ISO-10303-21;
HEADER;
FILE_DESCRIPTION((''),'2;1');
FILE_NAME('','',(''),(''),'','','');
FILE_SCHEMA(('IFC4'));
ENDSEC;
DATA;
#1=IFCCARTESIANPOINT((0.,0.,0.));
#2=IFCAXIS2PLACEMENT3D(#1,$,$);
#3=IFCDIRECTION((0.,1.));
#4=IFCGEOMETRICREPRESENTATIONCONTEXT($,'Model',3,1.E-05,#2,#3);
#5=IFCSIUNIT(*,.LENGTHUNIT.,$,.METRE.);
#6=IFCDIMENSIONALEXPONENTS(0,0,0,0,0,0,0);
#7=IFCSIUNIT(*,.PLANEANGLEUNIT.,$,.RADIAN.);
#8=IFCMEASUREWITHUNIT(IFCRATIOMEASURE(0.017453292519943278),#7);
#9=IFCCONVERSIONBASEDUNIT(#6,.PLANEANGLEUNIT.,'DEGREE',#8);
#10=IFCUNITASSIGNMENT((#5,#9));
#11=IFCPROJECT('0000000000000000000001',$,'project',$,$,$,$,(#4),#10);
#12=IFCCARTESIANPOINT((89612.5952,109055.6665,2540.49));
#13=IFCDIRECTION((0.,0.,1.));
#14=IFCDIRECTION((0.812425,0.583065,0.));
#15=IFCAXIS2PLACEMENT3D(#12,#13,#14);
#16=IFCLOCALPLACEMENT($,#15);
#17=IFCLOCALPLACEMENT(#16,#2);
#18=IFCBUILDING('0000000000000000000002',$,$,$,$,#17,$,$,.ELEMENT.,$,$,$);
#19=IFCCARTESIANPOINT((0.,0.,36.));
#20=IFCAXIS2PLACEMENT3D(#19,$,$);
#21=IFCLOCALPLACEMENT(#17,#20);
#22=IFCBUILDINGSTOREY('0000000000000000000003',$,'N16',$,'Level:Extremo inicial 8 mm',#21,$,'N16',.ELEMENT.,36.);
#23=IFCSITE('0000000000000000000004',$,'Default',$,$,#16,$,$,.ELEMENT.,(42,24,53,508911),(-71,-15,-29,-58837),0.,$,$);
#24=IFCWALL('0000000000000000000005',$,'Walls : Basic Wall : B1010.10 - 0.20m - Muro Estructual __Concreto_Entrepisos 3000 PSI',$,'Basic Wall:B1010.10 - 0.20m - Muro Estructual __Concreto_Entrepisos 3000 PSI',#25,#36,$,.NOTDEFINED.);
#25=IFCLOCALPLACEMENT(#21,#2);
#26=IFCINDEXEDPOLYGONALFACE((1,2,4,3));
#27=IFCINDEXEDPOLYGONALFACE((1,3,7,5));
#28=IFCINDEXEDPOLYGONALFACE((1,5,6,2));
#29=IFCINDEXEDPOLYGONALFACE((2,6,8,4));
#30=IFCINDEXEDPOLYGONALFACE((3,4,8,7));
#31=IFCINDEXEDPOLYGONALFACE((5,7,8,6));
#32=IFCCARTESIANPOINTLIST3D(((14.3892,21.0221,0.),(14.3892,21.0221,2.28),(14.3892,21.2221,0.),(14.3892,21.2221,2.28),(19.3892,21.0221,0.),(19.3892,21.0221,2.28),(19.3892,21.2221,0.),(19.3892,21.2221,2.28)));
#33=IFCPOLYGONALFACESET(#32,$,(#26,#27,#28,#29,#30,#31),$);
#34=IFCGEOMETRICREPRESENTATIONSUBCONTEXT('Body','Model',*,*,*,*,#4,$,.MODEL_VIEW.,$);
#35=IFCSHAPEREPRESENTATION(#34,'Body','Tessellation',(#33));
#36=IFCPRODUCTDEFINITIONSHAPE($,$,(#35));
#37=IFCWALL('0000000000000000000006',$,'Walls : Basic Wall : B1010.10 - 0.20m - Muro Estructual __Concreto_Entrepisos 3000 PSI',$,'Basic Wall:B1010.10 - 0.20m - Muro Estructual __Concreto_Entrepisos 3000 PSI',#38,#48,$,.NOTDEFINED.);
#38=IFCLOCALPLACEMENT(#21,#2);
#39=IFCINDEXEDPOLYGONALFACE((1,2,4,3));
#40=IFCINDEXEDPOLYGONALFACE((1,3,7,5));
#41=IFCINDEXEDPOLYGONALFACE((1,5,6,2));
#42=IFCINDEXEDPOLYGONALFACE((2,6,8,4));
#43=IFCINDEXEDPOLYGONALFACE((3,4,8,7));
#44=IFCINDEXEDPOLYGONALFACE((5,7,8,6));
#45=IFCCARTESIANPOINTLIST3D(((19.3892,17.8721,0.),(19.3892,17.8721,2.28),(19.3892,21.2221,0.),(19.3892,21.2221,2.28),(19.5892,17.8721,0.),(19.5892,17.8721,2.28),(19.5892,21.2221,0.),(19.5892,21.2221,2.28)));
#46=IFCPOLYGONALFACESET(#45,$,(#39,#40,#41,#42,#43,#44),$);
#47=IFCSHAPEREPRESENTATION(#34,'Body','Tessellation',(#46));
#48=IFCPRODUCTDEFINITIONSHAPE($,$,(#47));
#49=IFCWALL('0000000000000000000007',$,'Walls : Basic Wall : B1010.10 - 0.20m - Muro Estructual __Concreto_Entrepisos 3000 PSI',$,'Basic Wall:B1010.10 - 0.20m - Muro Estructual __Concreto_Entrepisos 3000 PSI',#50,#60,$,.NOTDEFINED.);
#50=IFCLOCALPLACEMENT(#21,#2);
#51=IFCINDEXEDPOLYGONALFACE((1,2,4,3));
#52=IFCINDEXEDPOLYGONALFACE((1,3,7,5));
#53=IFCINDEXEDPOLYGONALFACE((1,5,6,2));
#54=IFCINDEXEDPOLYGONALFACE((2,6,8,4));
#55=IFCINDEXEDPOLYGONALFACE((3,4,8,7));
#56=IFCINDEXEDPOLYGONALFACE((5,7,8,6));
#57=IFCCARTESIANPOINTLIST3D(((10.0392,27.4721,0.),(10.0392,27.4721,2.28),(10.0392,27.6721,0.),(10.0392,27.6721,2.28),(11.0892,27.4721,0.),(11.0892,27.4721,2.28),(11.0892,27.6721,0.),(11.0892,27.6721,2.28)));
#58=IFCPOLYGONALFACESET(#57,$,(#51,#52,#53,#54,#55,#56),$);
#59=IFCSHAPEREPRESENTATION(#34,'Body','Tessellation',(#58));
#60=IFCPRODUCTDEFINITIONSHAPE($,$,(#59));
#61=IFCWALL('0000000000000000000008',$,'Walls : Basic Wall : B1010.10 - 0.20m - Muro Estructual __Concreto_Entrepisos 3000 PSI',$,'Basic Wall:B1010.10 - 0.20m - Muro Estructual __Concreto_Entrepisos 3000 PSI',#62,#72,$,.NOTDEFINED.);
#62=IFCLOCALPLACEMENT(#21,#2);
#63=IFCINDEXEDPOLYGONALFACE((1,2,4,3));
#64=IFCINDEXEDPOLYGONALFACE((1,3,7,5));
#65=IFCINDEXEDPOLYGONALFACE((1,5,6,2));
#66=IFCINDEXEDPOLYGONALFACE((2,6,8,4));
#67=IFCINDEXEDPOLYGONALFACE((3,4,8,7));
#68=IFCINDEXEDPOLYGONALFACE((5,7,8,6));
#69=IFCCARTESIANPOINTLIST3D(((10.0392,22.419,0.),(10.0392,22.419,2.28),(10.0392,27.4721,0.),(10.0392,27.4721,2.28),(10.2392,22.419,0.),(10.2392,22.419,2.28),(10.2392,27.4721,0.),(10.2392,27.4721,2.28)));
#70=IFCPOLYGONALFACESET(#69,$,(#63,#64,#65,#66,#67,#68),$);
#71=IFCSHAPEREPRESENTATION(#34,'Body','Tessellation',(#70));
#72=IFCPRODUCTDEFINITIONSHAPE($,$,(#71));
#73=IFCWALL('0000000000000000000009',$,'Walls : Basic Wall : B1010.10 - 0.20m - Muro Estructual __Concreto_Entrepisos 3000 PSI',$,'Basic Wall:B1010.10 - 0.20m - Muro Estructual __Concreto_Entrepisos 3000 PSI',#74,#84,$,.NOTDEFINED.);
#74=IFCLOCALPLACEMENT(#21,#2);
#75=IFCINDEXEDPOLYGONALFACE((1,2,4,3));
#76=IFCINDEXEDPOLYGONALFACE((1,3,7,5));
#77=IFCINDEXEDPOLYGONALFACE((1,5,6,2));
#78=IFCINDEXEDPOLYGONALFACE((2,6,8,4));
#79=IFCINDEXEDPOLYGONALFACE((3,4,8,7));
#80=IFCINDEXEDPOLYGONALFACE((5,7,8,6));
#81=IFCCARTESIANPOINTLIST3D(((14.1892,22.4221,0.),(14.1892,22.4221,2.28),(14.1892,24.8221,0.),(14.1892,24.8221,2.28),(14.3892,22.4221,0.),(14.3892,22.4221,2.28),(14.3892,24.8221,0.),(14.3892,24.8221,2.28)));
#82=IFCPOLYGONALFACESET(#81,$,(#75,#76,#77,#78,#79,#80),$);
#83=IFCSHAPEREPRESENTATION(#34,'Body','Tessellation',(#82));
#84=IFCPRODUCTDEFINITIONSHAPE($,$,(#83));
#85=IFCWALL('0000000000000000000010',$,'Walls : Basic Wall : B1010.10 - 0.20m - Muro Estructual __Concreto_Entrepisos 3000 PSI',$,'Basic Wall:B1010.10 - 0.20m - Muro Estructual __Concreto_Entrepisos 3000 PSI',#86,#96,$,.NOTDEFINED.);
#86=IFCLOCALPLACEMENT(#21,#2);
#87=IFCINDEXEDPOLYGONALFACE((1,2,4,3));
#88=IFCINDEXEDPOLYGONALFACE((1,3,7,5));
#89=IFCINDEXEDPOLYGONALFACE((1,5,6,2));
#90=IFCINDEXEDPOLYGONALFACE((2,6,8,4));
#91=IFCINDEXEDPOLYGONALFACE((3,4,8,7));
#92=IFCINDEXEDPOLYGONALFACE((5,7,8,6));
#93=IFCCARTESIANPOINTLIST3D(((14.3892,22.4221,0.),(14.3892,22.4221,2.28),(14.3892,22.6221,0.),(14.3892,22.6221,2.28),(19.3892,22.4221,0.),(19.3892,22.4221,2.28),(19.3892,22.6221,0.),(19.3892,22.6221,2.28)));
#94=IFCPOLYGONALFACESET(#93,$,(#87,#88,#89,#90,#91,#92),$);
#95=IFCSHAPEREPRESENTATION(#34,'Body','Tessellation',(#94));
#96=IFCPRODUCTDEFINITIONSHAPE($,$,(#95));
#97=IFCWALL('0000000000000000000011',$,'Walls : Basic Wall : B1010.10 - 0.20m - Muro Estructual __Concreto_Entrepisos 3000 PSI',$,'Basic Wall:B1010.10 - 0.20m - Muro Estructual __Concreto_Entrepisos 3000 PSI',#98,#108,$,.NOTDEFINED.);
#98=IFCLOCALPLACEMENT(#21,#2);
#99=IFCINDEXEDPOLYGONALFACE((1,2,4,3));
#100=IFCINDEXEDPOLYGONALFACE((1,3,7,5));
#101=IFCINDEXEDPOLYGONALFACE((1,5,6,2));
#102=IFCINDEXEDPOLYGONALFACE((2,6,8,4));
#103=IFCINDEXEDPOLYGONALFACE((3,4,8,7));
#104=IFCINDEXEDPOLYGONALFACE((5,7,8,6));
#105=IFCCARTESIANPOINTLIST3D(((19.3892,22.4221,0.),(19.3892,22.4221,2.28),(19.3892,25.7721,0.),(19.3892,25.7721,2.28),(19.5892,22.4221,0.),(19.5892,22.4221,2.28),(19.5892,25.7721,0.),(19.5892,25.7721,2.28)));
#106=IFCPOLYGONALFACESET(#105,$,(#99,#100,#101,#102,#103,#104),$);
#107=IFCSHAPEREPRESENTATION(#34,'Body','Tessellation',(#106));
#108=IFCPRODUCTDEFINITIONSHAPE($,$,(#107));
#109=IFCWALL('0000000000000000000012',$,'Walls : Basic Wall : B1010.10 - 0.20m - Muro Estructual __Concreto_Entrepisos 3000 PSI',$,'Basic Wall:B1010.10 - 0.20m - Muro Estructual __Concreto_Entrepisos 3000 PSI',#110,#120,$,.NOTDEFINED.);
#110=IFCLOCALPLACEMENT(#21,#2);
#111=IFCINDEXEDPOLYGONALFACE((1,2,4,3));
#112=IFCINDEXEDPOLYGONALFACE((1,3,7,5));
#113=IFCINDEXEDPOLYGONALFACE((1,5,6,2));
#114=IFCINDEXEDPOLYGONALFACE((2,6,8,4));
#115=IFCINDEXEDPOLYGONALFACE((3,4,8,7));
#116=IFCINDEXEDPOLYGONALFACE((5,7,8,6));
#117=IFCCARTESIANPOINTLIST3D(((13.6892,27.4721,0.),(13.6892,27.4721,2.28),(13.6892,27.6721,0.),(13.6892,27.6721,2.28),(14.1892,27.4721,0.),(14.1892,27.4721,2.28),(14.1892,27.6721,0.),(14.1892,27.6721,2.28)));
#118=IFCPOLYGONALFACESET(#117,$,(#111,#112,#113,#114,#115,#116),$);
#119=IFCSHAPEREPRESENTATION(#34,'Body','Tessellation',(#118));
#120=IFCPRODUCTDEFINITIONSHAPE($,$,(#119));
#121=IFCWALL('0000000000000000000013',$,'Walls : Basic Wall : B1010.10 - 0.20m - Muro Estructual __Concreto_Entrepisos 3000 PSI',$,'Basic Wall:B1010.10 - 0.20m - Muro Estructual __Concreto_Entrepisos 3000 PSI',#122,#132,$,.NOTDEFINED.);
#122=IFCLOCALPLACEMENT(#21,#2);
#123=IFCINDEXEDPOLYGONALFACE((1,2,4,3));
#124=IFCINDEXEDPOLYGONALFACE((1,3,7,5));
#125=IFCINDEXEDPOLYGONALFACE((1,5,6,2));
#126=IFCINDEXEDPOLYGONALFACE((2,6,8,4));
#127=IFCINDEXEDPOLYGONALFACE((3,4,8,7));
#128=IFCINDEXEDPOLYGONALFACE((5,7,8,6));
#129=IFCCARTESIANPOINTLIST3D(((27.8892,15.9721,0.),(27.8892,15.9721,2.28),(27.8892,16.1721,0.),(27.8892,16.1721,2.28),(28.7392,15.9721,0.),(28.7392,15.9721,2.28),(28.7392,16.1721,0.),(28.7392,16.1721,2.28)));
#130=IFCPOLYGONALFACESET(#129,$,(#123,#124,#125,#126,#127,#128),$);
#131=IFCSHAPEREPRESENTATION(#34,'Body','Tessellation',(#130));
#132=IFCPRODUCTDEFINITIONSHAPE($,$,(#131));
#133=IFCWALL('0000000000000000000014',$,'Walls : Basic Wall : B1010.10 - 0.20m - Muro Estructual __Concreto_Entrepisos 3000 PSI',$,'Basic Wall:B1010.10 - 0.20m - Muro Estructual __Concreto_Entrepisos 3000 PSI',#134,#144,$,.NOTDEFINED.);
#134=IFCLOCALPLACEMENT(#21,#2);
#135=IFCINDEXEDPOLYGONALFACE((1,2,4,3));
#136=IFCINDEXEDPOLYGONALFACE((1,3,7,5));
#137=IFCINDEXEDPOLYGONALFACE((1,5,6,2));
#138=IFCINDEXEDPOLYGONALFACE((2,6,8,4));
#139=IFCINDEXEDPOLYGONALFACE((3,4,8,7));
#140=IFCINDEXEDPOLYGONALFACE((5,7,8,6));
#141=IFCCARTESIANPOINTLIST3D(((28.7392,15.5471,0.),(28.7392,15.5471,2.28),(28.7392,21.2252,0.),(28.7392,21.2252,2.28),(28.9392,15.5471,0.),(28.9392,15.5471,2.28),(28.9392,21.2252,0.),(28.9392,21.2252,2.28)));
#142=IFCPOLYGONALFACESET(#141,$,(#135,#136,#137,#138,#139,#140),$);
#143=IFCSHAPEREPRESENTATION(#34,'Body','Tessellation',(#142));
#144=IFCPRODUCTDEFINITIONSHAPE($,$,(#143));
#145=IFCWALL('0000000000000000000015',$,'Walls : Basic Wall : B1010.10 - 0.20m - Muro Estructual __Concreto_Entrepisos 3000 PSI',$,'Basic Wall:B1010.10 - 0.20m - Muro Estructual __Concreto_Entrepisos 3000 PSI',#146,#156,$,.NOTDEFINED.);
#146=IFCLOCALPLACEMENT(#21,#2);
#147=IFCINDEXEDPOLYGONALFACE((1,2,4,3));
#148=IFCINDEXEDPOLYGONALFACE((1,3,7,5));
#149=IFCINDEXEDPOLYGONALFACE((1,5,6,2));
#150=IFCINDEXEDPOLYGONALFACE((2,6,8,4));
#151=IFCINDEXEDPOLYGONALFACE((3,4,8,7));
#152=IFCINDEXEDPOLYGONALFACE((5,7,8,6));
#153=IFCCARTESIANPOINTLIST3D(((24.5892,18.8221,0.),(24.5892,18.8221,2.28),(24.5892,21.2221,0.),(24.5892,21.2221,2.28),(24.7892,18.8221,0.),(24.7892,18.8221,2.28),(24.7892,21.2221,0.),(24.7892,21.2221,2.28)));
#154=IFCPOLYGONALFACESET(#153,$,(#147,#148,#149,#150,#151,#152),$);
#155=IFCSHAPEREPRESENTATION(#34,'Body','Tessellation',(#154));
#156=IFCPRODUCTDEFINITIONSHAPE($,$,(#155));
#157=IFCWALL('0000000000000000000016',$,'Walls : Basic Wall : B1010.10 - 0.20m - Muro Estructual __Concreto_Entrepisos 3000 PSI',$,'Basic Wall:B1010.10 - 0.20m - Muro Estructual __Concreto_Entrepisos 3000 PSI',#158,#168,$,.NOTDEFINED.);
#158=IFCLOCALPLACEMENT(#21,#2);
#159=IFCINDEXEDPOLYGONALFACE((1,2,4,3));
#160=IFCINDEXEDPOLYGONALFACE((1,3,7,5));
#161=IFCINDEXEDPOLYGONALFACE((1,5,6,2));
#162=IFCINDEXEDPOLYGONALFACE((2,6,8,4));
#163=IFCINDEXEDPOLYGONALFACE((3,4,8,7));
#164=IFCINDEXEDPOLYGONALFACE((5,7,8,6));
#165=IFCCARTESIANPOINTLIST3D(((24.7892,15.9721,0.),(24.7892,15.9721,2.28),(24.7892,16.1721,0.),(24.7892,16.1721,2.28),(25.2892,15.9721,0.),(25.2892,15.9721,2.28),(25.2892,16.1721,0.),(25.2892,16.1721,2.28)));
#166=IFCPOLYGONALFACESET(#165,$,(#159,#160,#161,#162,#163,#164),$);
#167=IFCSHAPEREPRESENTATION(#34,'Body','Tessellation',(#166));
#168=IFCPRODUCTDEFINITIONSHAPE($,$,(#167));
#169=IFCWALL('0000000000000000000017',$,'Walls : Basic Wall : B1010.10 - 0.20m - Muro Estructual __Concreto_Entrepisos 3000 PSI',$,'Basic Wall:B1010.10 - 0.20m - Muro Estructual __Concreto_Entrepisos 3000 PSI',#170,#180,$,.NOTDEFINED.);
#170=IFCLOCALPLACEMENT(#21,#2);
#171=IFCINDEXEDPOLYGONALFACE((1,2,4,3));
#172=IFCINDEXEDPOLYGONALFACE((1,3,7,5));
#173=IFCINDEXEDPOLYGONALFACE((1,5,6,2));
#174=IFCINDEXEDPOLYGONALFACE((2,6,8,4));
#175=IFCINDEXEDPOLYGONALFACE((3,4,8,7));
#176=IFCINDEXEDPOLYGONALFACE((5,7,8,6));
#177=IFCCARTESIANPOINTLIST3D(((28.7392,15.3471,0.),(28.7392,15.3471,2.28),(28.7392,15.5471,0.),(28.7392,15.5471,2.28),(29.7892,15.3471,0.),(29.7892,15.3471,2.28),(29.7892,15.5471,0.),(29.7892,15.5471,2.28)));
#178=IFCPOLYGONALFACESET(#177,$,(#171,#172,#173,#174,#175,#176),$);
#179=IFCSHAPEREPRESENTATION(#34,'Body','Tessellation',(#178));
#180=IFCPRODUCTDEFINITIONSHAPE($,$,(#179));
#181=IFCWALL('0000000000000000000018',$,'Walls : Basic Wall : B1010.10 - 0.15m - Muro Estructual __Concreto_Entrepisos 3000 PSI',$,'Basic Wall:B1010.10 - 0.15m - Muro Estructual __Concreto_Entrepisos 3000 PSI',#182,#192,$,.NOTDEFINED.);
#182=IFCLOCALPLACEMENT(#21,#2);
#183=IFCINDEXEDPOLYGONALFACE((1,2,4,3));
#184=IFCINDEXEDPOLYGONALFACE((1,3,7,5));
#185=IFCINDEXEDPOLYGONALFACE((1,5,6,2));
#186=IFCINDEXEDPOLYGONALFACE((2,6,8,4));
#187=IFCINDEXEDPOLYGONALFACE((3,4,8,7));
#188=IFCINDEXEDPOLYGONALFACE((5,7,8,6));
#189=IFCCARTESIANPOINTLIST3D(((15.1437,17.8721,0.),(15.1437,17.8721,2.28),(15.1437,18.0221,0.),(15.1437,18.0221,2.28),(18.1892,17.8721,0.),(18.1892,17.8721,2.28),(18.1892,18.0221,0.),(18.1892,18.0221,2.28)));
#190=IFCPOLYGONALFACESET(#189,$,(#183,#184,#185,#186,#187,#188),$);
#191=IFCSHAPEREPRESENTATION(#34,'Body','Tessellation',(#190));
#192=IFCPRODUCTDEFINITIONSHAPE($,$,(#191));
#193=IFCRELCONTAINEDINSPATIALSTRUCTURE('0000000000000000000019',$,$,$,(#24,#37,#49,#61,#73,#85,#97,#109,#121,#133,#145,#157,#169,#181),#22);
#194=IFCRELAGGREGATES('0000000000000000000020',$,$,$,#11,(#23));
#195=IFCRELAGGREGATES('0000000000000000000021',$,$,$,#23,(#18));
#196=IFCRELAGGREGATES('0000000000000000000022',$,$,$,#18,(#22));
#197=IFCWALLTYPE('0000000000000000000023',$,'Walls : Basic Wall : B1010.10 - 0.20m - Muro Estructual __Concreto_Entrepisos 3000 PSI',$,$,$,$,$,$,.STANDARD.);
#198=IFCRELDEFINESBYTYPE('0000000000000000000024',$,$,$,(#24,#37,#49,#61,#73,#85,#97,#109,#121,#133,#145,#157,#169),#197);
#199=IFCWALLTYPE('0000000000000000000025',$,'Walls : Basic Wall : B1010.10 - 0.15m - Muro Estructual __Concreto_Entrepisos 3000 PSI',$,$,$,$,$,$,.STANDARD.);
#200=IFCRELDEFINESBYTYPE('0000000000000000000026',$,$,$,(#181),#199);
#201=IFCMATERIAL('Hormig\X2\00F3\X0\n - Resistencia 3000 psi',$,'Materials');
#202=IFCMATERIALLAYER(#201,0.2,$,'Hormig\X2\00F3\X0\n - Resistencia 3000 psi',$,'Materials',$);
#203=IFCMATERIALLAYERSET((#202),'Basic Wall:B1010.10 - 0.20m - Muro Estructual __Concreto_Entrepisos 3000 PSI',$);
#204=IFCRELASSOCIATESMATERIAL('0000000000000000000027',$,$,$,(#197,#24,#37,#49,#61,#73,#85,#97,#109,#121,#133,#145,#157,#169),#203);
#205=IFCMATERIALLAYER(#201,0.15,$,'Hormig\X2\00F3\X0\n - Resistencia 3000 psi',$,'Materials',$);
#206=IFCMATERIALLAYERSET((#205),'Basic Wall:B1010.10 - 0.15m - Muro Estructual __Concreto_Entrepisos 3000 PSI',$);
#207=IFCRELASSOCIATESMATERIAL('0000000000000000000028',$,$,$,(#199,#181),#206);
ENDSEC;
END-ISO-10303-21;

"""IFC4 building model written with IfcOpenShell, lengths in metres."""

from ifc_helpers import new_model, entity, si_unit, converted_unit, direction, frame, frame_2d, origin, place, context, subcontext, project, spatial, rectangle, extrude, material, layer, layer_set, layer_usage, type_object, element, save


model = new_model("IFC4")

# Units and contexts
model_context = context("Model", 3, precision=1e-05, world=origin(), true_north=direction((0.0, 1.0)))
body_context = subcontext(model_context, "Body", "Model", "MODEL_VIEW")
ifc_project = project(units=[si_unit("LENGTHUNIT", "METRE"), converted_unit("PLANEANGLEUNIT", "DEGREE", entity("IfcRatioMeasure", 0.017453292519943278), si_unit("PLANEANGLEUNIT", "RADIAN"), dimensions=[0, 0, 0, 0, 0, 0, 0])], contexts=[model_context])

# Site, building, storey
site_placement = place(None, frame((89612.5952, 109055.6665, 2540.49), z_axis=(0.0, 0.0, 1.0), x_axis=(0.812425, 0.583065, 0.0)))
site = spatial("IfcSite", under=ifc_project, at=site_placement, Name="Default", CompositionType="ELEMENT", RefLatitude=(42, 24, 53, 508911), RefLongitude=(-71, -15, -29, -58837), RefElevation=0.0)
building_placement = place(site_placement, origin())
building = spatial("IfcBuilding", under=site, at=building_placement, CompositionType="ELEMENT")
storey_placement = place(building_placement, frame((0.0, 0.0, 36.0)))
storey = spatial("IfcBuildingStorey", under=building, at=storey_placement, Name="N16", ObjectType="Level:Extremo inicial 8 mm", LongName="N16", CompositionType="ELEMENT", Elevation=36.0)

# Walls
ifc_material = material(Name="Hormigón - Resistencia 3000 psi", Category="Materials")
ifc_layer_1 = layer(ifc_material, 0.2, Name="Hormigón - Resistencia 3000 psi", Category="Materials")
ifc_layer_set_1 = layer_set([ifc_layer_1], Name="Basic Wall:B1010.10 - 0.20m - Muro Estructual __Concreto_Entrepisos 3000 PSI")
ifc_layer_usage_1 = layer_usage(ifc_layer_set_1, "AXIS2", "NEGATIVE", 0.1)
wall_type_1 = type_object("IfcWallType", Name="Walls : Basic Wall : B1010.10 - 0.20m - Muro Estructual __Concreto_Entrepisos 3000 PSI", PredefinedType="STANDARD", material=ifc_layer_set_1)
wall_1_placement = place(storey_placement, frame((14.3892, 21.1221, 0.0)))
element("IfcWall", 1, at=wall_1_placement, inside=storey, type_object=wall_type_1, material=ifc_layer_usage_1, Name="Walls : Basic Wall : B1010.10 - 0.20m - Muro Estructual __Concreto_Entrepisos 3000 PSI", ObjectType="Basic Wall:B1010.10 - 0.20m - Muro Estructual __Concreto_Entrepisos 3000 PSI", PredefinedType="NOTDEFINED", context=body_context, shape_type="SweptSolid", body=[
    extrude(rectangle(XDim=5.0, YDim=0.2, at=frame_2d((2.5, 0.0), x_axis=(-1.0, 0.0))), origin(), (0.0, 0.0, 1.0), 2.28),
])
ifc_layer_usage_2 = layer_usage(ifc_layer_set_1, "AXIS2", "NEGATIVE", 0.1)
wall_2_placement = place(storey_placement, frame((19.4892, 21.2221, 0.0), z_axis=(0.0, 0.0, 1.0), x_axis=(0.0, -1.0, 0.0)))
element("IfcWall", 2, at=wall_2_placement, inside=storey, type_object=wall_type_1, material=ifc_layer_usage_2, Name="Walls : Basic Wall : B1010.10 - 0.20m - Muro Estructual __Concreto_Entrepisos 3000 PSI", ObjectType="Basic Wall:B1010.10 - 0.20m - Muro Estructual __Concreto_Entrepisos 3000 PSI", PredefinedType="NOTDEFINED", context=body_context, shape_type="SweptSolid", body=[
    extrude(rectangle(XDim=3.35, YDim=0.2, at=frame_2d((1.675, 0.0), x_axis=(-1.0, 0.0))), origin(), (0.0, 0.0, 1.0), 2.28),
])
ifc_layer_usage_3 = layer_usage(ifc_layer_set_1, "AXIS2", "POSITIVE", -0.1)
wall_3_placement = place(storey_placement, frame((11.0892, 27.5721, 0.0), z_axis=(0.0, 0.0, 1.0), x_axis=(-1.0, 0.0, 0.0)))
element("IfcWall", 3, at=wall_3_placement, inside=storey, type_object=wall_type_1, material=ifc_layer_usage_3, Name="Walls : Basic Wall : B1010.10 - 0.20m - Muro Estructual __Concreto_Entrepisos 3000 PSI", ObjectType="Basic Wall:B1010.10 - 0.20m - Muro Estructual __Concreto_Entrepisos 3000 PSI", PredefinedType="NOTDEFINED", context=body_context, shape_type="SweptSolid", body=[
    extrude(rectangle(XDim=1.05, YDim=0.2, at=frame_2d((0.525, 0.0), x_axis=(-1.0, 0.0))), origin(), (0.0, 0.0, 1.0), 2.28),
])
ifc_layer_usage_4 = layer_usage(ifc_layer_set_1, "AXIS2", "POSITIVE", -0.1)
wall_4_placement = place(storey_placement, frame((10.1392, 27.4721, 0.0), z_axis=(0.0, 0.0, 1.0), x_axis=(0.0, -1.0, 0.0)))
element("IfcWall", 4, at=wall_4_placement, inside=storey, type_object=wall_type_1, material=ifc_layer_usage_4, Name="Walls : Basic Wall : B1010.10 - 0.20m - Muro Estructual __Concreto_Entrepisos 3000 PSI", ObjectType="Basic Wall:B1010.10 - 0.20m - Muro Estructual __Concreto_Entrepisos 3000 PSI", PredefinedType="NOTDEFINED", context=body_context, shape_type="SweptSolid", body=[
    extrude(rectangle(XDim=5.0531, YDim=0.2, at=frame_2d((2.5265, 0.0), x_axis=(-1.0, 0.0))), origin(), (0.0, 0.0, 1.0), 2.28),
])
ifc_layer_usage_5 = layer_usage(ifc_layer_set_1, "AXIS2", "POSITIVE", -0.1)
wall_5_placement = place(storey_placement, frame((14.2892, 24.8221, 0.0), z_axis=(0.0, 0.0, 1.0), x_axis=(0.0, -1.0, 0.0)))
element("IfcWall", 5, at=wall_5_placement, inside=storey, type_object=wall_type_1, material=ifc_layer_usage_5, Name="Walls : Basic Wall : B1010.10 - 0.20m - Muro Estructual __Concreto_Entrepisos 3000 PSI", ObjectType="Basic Wall:B1010.10 - 0.20m - Muro Estructual __Concreto_Entrepisos 3000 PSI", PredefinedType="NOTDEFINED", context=body_context, shape_type="SweptSolid", body=[
    extrude(rectangle(XDim=2.4, YDim=0.2, at=frame_2d((1.2, 0.0), x_axis=(-1.0, 0.0))), origin(), (0.0, 0.0, 1.0), 2.28),
])
ifc_layer_usage_6 = layer_usage(ifc_layer_set_1, "AXIS2", "POSITIVE", -0.1)
wall_6_placement = place(storey_placement, frame((14.3892, 22.5221, 0.0)))
element("IfcWall", 6, at=wall_6_placement, inside=storey, type_object=wall_type_1, material=ifc_layer_usage_6, Name="Walls : Basic Wall : B1010.10 - 0.20m - Muro Estructual __Concreto_Entrepisos 3000 PSI", ObjectType="Basic Wall:B1010.10 - 0.20m - Muro Estructual __Concreto_Entrepisos 3000 PSI", PredefinedType="NOTDEFINED", context=body_context, shape_type="SweptSolid", body=[
    extrude(rectangle(XDim=5.0, YDim=0.2, at=frame_2d((2.5, 0.0), x_axis=(-1.0, 0.0))), origin(), (0.0, 0.0, 1.0), 2.28),
])
ifc_layer_usage_7 = layer_usage(ifc_layer_set_1, "AXIS2", "POSITIVE", -0.1)
wall_7_placement = place(storey_placement, frame((19.4892, 22.4221, 0.0), z_axis=(0.0, 0.0, 1.0), x_axis=(0.0, 1.0, 0.0)))
element("IfcWall", 7, at=wall_7_placement, inside=storey, type_object=wall_type_1, material=ifc_layer_usage_7, Name="Walls : Basic Wall : B1010.10 - 0.20m - Muro Estructual __Concreto_Entrepisos 3000 PSI", ObjectType="Basic Wall:B1010.10 - 0.20m - Muro Estructual __Concreto_Entrepisos 3000 PSI", PredefinedType="NOTDEFINED", context=body_context, shape_type="SweptSolid", body=[
    extrude(rectangle(XDim=3.35, YDim=0.2, at=frame_2d((1.675, 0.0), x_axis=(-1.0, 0.0))), origin(), (0.0, 0.0, 1.0), 2.28),
])
ifc_layer_usage_8 = layer_usage(ifc_layer_set_1, "AXIS2", "POSITIVE", -0.1)
wall_8_placement = place(storey_placement, frame((13.6892, 27.5721, 0.0)))
element("IfcWall", 8, at=wall_8_placement, inside=storey, type_object=wall_type_1, material=ifc_layer_usage_8, Name="Walls : Basic Wall : B1010.10 - 0.20m - Muro Estructual __Concreto_Entrepisos 3000 PSI", ObjectType="Basic Wall:B1010.10 - 0.20m - Muro Estructual __Concreto_Entrepisos 3000 PSI", PredefinedType="NOTDEFINED", context=body_context, shape_type="SweptSolid", body=[
    extrude(rectangle(XDim=0.5, YDim=0.2, at=frame_2d((0.25, 0.0), x_axis=(-1.0, 0.0))), origin(), (0.0, 0.0, 1.0), 2.28),
])
ifc_layer_usage_9 = layer_usage(ifc_layer_set_1, "AXIS2", "POSITIVE", -0.1)
wall_9_placement = place(storey_placement, frame((27.8892, 16.0721, 0.0)))
element("IfcWall", 9, at=wall_9_placement, inside=storey, type_object=wall_type_1, material=ifc_layer_usage_9, Name="Walls : Basic Wall : B1010.10 - 0.20m - Muro Estructual __Concreto_Entrepisos 3000 PSI", ObjectType="Basic Wall:B1010.10 - 0.20m - Muro Estructual __Concreto_Entrepisos 3000 PSI", PredefinedType="NOTDEFINED", context=body_context, shape_type="SweptSolid", body=[
    extrude(rectangle(XDim=0.85, YDim=0.2, at=frame_2d((0.425, 0.0), x_axis=(-1.0, 0.0))), origin(), (0.0, 0.0, 1.0), 2.28),
])
ifc_layer_usage_10 = layer_usage(ifc_layer_set_1, "AXIS2", "POSITIVE", -0.1)
wall_10_placement = place(storey_placement, frame((28.8392, 15.5471, 0.0), z_axis=(0.0, 0.0, 1.0), x_axis=(0.0, 1.0, 0.0)))
element("IfcWall", 10, at=wall_10_placement, inside=storey, type_object=wall_type_1, material=ifc_layer_usage_10, Name="Walls : Basic Wall : B1010.10 - 0.20m - Muro Estructual __Concreto_Entrepisos 3000 PSI", ObjectType="Basic Wall:B1010.10 - 0.20m - Muro Estructual __Concreto_Entrepisos 3000 PSI", PredefinedType="NOTDEFINED", context=body_context, shape_type="SweptSolid", body=[
    extrude(rectangle(XDim=5.6781, YDim=0.2, at=frame_2d((2.839, 0.0), x_axis=(-1.0, 0.0))), origin(), (0.0, 0.0, 1.0), 2.28),
])
ifc_layer_usage_11 = layer_usage(ifc_layer_set_1, "AXIS2", "POSITIVE", -0.1)
wall_11_placement = place(storey_placement, frame((24.6892, 18.8221, 0.0), z_axis=(0.0, 0.0, 1.0), x_axis=(0.0, 1.0, 0.0)))
element("IfcWall", 11, at=wall_11_placement, inside=storey, type_object=wall_type_1, material=ifc_layer_usage_11, Name="Walls : Basic Wall : B1010.10 - 0.20m - Muro Estructual __Concreto_Entrepisos 3000 PSI", ObjectType="Basic Wall:B1010.10 - 0.20m - Muro Estructual __Concreto_Entrepisos 3000 PSI", PredefinedType="NOTDEFINED", context=body_context, shape_type="SweptSolid", body=[
    extrude(rectangle(XDim=2.4, YDim=0.2, at=frame_2d((1.2, 0.0), x_axis=(-1.0, 0.0))), origin(), (0.0, 0.0, 1.0), 2.28),
])
ifc_layer_usage_12 = layer_usage(ifc_layer_set_1, "AXIS2", "POSITIVE", -0.1)
wall_12_placement = place(storey_placement, frame((25.2892, 16.0721, 0.0), z_axis=(0.0, 0.0, 1.0), x_axis=(-1.0, 0.0, 0.0)))
element("IfcWall", 12, at=wall_12_placement, inside=storey, type_object=wall_type_1, material=ifc_layer_usage_12, Name="Walls : Basic Wall : B1010.10 - 0.20m - Muro Estructual __Concreto_Entrepisos 3000 PSI", ObjectType="Basic Wall:B1010.10 - 0.20m - Muro Estructual __Concreto_Entrepisos 3000 PSI", PredefinedType="NOTDEFINED", context=body_context, shape_type="SweptSolid", body=[
    extrude(rectangle(XDim=0.5, YDim=0.2, at=frame_2d((0.25, 0.0), x_axis=(-1.0, 0.0))), origin(), (0.0, 0.0, 1.0), 2.28),
])
ifc_layer_usage_13 = layer_usage(ifc_layer_set_1, "AXIS2", "NEGATIVE", 0.1)
wall_13_placement = place(storey_placement, frame((29.7892, 15.4471, 0.0), z_axis=(0.0, 0.0, 1.0), x_axis=(-1.0, 0.0, 0.0)))
element("IfcWall", 13, at=wall_13_placement, inside=storey, type_object=wall_type_1, material=ifc_layer_usage_13, Name="Walls : Basic Wall : B1010.10 - 0.20m - Muro Estructual __Concreto_Entrepisos 3000 PSI", ObjectType="Basic Wall:B1010.10 - 0.20m - Muro Estructual __Concreto_Entrepisos 3000 PSI", PredefinedType="NOTDEFINED", context=body_context, shape_type="SweptSolid", body=[
    extrude(rectangle(XDim=1.05, YDim=0.2, at=frame_2d((0.525, 0.0), x_axis=(-1.0, 0.0))), origin(), (0.0, 0.0, 1.0), 2.28),
])
ifc_layer_2 = layer(ifc_material, 0.15, Name="Hormigón - Resistencia 3000 psi", Category="Materials")
ifc_layer_set_2 = layer_set([ifc_layer_2], Name="Basic Wall:B1010.10 - 0.15m - Muro Estructual __Concreto_Entrepisos 3000 PSI")
ifc_layer_usage_14 = layer_usage(ifc_layer_set_2, "AXIS2", "NEGATIVE", 0.075)
wall_type_2 = type_object("IfcWallType", Name="Walls : Basic Wall : B1010.10 - 0.15m - Muro Estructual __Concreto_Entrepisos 3000 PSI", PredefinedType="STANDARD", material=ifc_layer_set_2)
wall_14_placement = place(storey_placement, frame((18.1892, 17.9471, 0.0), z_axis=(0.0, 0.0, 1.0), x_axis=(-1.0, 0.0, 0.0)))
element("IfcWall", 14, at=wall_14_placement, inside=storey, type_object=wall_type_2, material=ifc_layer_usage_14, Name="Walls : Basic Wall : B1010.10 - 0.15m - Muro Estructual __Concreto_Entrepisos 3000 PSI", ObjectType="Basic Wall:B1010.10 - 0.15m - Muro Estructual __Concreto_Entrepisos 3000 PSI", PredefinedType="NOTDEFINED", context=body_context, shape_type="SweptSolid", body=[
    extrude(rectangle(XDim=3.0455, YDim=0.15, at=frame_2d((1.5228, 0.0), x_axis=(-1.0, 0.0))), origin(), (0.0, 0.0, 1.0), 2.28),
])

save(model, "model.ifc")
